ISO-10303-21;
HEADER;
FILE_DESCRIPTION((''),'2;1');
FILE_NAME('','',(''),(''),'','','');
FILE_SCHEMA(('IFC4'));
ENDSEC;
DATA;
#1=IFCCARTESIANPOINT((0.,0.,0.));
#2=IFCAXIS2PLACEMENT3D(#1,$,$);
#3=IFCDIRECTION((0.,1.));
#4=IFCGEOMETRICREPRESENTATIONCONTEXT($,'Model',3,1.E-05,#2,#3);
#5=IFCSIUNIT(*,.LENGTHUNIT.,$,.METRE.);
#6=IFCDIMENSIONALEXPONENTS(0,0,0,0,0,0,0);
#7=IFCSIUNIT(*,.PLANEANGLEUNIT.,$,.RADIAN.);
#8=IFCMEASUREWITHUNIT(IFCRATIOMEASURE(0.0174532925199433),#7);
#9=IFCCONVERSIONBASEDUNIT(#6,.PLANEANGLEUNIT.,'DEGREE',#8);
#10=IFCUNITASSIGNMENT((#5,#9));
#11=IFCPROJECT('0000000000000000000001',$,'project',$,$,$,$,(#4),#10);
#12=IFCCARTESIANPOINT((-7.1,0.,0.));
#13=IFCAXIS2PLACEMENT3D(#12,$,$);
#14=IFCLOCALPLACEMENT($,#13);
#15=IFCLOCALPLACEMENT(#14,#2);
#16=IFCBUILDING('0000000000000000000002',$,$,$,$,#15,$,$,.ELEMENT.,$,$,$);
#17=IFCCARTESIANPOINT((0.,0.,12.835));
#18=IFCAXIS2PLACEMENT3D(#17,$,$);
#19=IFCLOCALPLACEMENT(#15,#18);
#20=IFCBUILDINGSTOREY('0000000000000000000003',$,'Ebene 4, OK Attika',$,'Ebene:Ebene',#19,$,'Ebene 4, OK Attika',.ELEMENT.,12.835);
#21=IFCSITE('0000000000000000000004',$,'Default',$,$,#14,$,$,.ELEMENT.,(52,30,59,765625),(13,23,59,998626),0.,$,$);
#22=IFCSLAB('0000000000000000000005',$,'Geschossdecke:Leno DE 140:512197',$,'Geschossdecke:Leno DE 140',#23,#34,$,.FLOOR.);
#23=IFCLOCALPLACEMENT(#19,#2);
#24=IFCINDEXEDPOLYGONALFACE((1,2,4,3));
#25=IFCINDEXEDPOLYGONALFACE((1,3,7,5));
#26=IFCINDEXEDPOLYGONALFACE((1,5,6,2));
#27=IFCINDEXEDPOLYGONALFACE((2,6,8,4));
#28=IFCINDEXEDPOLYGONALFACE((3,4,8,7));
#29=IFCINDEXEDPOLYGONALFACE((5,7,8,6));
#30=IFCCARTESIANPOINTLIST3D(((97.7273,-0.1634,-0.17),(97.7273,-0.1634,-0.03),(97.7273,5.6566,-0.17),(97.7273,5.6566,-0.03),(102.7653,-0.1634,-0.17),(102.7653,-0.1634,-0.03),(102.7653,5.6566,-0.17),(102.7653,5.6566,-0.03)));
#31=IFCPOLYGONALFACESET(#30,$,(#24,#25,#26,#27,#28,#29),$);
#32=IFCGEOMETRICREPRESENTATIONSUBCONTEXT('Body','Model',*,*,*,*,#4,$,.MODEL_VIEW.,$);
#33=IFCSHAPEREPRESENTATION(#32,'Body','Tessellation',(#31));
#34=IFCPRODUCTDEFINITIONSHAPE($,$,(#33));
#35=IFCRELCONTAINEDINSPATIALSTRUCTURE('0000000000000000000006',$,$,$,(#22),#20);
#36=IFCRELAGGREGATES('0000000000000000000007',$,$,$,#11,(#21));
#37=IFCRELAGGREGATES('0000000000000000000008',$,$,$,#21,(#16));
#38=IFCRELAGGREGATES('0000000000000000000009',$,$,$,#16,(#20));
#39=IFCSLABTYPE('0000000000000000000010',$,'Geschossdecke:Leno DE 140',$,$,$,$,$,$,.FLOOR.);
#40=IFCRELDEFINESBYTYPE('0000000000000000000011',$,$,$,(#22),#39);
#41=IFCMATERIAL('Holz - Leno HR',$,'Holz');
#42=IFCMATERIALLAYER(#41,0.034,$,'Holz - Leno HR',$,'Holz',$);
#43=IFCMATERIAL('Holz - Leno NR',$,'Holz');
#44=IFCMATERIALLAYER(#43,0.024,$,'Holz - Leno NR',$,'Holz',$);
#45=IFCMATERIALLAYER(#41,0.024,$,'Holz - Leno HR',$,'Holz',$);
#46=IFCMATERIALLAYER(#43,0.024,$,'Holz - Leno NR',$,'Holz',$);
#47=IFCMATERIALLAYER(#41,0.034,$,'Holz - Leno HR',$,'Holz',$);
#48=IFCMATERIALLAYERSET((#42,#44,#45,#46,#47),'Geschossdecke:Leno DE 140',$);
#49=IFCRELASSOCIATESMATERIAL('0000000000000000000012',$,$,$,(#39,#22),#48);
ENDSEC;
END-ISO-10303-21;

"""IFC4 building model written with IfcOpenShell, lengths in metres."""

from ifc_helpers import new_model, entity, si_unit, converted_unit, direction, frame, frame_2d, origin, place, context, subcontext, project, spatial, rectangle, extrude, material, layer, layer_set, layer_usage, type_object, element, save


model = new_model("IFC4")

# Units and contexts
model_context = context("Model", 3, precision=1e-05, world=origin(), true_north=direction((0.0, 1.0)))
body_context = subcontext(model_context, "Body", "Model", "MODEL_VIEW")
ifc_project = project(units=[si_unit("LENGTHUNIT", "METRE"), converted_unit("PLANEANGLEUNIT", "DEGREE", entity("IfcRatioMeasure", 0.0174532925199433), si_unit("PLANEANGLEUNIT", "RADIAN"), dimensions=[0, 0, 0, 0, 0, 0, 0])], contexts=[model_context])

# Site, building, storey
site_placement = place(None, frame((-7.1, 0.0, 0.0)))
site = spatial("IfcSite", under=ifc_project, at=site_placement, Name="Default", CompositionType="ELEMENT", RefLatitude=(52, 30, 59, 765625), RefLongitude=(13, 23, 59, 998626), RefElevation=0.0)
building_placement = place(site_placement, origin())
building = spatial("IfcBuilding", under=site, at=building_placement, CompositionType="ELEMENT")
storey_placement = place(building_placement, frame((0.0, 0.0, 12.835)))
storey = spatial("IfcBuildingStorey", under=building, at=storey_placement, Name="Ebene 4, OK Attika", ObjectType="Ebene:Ebene", LongName="Ebene 4, OK Attika", CompositionType="ELEMENT", Elevation=12.835)

# Slab
ifc_material_1 = material(Name="Holz - Leno HR", Category="Holz")
ifc_layer_1 = layer(ifc_material_1, 0.034, Name="Holz - Leno HR", Category="Holz")
ifc_material_2 = material(Name="Holz - Leno NR", Category="Holz")
ifc_layer_2 = layer(ifc_material_2, 0.024, Name="Holz - Leno NR", Category="Holz")
ifc_layer_3 = layer(ifc_material_1, 0.024, Name="Holz - Leno HR", Category="Holz")
ifc_layer_4 = layer(ifc_material_2, 0.024, Name="Holz - Leno NR", Category="Holz")
ifc_layer_5 = layer(ifc_material_1, 0.034, Name="Holz - Leno HR", Category="Holz")
ifc_layer_set = layer_set([ifc_layer_1, ifc_layer_2, ifc_layer_3, ifc_layer_4, ifc_layer_5], Name="Geschossdecke:Leno DE 140")
ifc_layer_usage = layer_usage(ifc_layer_set, "AXIS3", "POSITIVE", 0.0)
slab_type = type_object("IfcSlabType", Name="Geschossdecke:Leno DE 140", PredefinedType="FLOOR", material=ifc_layer_set)
slab_placement = place(storey_placement, origin())
element("IfcSlab", 1, at=slab_placement, inside=storey, type_object=slab_type, material=ifc_layer_usage, Name="Geschossdecke:Leno DE 140:512197", ObjectType="Geschossdecke:Leno DE 140", PredefinedType="FLOOR", context=body_context, shape_type="SweptSolid", body=[
    extrude(rectangle(XDim=5.82, YDim=5.038, at=frame_2d((0.0, 0.0), x_axis=(1.0, 0.0))), frame((100.2463, 2.7466, -0.03), z_axis=(0.0, 0.0, -1.0), x_axis=(0.0, 1.0, 0.0)), (0.0, 0.0, 1.0), 0.14),
])

save(model, "model.ifc")
